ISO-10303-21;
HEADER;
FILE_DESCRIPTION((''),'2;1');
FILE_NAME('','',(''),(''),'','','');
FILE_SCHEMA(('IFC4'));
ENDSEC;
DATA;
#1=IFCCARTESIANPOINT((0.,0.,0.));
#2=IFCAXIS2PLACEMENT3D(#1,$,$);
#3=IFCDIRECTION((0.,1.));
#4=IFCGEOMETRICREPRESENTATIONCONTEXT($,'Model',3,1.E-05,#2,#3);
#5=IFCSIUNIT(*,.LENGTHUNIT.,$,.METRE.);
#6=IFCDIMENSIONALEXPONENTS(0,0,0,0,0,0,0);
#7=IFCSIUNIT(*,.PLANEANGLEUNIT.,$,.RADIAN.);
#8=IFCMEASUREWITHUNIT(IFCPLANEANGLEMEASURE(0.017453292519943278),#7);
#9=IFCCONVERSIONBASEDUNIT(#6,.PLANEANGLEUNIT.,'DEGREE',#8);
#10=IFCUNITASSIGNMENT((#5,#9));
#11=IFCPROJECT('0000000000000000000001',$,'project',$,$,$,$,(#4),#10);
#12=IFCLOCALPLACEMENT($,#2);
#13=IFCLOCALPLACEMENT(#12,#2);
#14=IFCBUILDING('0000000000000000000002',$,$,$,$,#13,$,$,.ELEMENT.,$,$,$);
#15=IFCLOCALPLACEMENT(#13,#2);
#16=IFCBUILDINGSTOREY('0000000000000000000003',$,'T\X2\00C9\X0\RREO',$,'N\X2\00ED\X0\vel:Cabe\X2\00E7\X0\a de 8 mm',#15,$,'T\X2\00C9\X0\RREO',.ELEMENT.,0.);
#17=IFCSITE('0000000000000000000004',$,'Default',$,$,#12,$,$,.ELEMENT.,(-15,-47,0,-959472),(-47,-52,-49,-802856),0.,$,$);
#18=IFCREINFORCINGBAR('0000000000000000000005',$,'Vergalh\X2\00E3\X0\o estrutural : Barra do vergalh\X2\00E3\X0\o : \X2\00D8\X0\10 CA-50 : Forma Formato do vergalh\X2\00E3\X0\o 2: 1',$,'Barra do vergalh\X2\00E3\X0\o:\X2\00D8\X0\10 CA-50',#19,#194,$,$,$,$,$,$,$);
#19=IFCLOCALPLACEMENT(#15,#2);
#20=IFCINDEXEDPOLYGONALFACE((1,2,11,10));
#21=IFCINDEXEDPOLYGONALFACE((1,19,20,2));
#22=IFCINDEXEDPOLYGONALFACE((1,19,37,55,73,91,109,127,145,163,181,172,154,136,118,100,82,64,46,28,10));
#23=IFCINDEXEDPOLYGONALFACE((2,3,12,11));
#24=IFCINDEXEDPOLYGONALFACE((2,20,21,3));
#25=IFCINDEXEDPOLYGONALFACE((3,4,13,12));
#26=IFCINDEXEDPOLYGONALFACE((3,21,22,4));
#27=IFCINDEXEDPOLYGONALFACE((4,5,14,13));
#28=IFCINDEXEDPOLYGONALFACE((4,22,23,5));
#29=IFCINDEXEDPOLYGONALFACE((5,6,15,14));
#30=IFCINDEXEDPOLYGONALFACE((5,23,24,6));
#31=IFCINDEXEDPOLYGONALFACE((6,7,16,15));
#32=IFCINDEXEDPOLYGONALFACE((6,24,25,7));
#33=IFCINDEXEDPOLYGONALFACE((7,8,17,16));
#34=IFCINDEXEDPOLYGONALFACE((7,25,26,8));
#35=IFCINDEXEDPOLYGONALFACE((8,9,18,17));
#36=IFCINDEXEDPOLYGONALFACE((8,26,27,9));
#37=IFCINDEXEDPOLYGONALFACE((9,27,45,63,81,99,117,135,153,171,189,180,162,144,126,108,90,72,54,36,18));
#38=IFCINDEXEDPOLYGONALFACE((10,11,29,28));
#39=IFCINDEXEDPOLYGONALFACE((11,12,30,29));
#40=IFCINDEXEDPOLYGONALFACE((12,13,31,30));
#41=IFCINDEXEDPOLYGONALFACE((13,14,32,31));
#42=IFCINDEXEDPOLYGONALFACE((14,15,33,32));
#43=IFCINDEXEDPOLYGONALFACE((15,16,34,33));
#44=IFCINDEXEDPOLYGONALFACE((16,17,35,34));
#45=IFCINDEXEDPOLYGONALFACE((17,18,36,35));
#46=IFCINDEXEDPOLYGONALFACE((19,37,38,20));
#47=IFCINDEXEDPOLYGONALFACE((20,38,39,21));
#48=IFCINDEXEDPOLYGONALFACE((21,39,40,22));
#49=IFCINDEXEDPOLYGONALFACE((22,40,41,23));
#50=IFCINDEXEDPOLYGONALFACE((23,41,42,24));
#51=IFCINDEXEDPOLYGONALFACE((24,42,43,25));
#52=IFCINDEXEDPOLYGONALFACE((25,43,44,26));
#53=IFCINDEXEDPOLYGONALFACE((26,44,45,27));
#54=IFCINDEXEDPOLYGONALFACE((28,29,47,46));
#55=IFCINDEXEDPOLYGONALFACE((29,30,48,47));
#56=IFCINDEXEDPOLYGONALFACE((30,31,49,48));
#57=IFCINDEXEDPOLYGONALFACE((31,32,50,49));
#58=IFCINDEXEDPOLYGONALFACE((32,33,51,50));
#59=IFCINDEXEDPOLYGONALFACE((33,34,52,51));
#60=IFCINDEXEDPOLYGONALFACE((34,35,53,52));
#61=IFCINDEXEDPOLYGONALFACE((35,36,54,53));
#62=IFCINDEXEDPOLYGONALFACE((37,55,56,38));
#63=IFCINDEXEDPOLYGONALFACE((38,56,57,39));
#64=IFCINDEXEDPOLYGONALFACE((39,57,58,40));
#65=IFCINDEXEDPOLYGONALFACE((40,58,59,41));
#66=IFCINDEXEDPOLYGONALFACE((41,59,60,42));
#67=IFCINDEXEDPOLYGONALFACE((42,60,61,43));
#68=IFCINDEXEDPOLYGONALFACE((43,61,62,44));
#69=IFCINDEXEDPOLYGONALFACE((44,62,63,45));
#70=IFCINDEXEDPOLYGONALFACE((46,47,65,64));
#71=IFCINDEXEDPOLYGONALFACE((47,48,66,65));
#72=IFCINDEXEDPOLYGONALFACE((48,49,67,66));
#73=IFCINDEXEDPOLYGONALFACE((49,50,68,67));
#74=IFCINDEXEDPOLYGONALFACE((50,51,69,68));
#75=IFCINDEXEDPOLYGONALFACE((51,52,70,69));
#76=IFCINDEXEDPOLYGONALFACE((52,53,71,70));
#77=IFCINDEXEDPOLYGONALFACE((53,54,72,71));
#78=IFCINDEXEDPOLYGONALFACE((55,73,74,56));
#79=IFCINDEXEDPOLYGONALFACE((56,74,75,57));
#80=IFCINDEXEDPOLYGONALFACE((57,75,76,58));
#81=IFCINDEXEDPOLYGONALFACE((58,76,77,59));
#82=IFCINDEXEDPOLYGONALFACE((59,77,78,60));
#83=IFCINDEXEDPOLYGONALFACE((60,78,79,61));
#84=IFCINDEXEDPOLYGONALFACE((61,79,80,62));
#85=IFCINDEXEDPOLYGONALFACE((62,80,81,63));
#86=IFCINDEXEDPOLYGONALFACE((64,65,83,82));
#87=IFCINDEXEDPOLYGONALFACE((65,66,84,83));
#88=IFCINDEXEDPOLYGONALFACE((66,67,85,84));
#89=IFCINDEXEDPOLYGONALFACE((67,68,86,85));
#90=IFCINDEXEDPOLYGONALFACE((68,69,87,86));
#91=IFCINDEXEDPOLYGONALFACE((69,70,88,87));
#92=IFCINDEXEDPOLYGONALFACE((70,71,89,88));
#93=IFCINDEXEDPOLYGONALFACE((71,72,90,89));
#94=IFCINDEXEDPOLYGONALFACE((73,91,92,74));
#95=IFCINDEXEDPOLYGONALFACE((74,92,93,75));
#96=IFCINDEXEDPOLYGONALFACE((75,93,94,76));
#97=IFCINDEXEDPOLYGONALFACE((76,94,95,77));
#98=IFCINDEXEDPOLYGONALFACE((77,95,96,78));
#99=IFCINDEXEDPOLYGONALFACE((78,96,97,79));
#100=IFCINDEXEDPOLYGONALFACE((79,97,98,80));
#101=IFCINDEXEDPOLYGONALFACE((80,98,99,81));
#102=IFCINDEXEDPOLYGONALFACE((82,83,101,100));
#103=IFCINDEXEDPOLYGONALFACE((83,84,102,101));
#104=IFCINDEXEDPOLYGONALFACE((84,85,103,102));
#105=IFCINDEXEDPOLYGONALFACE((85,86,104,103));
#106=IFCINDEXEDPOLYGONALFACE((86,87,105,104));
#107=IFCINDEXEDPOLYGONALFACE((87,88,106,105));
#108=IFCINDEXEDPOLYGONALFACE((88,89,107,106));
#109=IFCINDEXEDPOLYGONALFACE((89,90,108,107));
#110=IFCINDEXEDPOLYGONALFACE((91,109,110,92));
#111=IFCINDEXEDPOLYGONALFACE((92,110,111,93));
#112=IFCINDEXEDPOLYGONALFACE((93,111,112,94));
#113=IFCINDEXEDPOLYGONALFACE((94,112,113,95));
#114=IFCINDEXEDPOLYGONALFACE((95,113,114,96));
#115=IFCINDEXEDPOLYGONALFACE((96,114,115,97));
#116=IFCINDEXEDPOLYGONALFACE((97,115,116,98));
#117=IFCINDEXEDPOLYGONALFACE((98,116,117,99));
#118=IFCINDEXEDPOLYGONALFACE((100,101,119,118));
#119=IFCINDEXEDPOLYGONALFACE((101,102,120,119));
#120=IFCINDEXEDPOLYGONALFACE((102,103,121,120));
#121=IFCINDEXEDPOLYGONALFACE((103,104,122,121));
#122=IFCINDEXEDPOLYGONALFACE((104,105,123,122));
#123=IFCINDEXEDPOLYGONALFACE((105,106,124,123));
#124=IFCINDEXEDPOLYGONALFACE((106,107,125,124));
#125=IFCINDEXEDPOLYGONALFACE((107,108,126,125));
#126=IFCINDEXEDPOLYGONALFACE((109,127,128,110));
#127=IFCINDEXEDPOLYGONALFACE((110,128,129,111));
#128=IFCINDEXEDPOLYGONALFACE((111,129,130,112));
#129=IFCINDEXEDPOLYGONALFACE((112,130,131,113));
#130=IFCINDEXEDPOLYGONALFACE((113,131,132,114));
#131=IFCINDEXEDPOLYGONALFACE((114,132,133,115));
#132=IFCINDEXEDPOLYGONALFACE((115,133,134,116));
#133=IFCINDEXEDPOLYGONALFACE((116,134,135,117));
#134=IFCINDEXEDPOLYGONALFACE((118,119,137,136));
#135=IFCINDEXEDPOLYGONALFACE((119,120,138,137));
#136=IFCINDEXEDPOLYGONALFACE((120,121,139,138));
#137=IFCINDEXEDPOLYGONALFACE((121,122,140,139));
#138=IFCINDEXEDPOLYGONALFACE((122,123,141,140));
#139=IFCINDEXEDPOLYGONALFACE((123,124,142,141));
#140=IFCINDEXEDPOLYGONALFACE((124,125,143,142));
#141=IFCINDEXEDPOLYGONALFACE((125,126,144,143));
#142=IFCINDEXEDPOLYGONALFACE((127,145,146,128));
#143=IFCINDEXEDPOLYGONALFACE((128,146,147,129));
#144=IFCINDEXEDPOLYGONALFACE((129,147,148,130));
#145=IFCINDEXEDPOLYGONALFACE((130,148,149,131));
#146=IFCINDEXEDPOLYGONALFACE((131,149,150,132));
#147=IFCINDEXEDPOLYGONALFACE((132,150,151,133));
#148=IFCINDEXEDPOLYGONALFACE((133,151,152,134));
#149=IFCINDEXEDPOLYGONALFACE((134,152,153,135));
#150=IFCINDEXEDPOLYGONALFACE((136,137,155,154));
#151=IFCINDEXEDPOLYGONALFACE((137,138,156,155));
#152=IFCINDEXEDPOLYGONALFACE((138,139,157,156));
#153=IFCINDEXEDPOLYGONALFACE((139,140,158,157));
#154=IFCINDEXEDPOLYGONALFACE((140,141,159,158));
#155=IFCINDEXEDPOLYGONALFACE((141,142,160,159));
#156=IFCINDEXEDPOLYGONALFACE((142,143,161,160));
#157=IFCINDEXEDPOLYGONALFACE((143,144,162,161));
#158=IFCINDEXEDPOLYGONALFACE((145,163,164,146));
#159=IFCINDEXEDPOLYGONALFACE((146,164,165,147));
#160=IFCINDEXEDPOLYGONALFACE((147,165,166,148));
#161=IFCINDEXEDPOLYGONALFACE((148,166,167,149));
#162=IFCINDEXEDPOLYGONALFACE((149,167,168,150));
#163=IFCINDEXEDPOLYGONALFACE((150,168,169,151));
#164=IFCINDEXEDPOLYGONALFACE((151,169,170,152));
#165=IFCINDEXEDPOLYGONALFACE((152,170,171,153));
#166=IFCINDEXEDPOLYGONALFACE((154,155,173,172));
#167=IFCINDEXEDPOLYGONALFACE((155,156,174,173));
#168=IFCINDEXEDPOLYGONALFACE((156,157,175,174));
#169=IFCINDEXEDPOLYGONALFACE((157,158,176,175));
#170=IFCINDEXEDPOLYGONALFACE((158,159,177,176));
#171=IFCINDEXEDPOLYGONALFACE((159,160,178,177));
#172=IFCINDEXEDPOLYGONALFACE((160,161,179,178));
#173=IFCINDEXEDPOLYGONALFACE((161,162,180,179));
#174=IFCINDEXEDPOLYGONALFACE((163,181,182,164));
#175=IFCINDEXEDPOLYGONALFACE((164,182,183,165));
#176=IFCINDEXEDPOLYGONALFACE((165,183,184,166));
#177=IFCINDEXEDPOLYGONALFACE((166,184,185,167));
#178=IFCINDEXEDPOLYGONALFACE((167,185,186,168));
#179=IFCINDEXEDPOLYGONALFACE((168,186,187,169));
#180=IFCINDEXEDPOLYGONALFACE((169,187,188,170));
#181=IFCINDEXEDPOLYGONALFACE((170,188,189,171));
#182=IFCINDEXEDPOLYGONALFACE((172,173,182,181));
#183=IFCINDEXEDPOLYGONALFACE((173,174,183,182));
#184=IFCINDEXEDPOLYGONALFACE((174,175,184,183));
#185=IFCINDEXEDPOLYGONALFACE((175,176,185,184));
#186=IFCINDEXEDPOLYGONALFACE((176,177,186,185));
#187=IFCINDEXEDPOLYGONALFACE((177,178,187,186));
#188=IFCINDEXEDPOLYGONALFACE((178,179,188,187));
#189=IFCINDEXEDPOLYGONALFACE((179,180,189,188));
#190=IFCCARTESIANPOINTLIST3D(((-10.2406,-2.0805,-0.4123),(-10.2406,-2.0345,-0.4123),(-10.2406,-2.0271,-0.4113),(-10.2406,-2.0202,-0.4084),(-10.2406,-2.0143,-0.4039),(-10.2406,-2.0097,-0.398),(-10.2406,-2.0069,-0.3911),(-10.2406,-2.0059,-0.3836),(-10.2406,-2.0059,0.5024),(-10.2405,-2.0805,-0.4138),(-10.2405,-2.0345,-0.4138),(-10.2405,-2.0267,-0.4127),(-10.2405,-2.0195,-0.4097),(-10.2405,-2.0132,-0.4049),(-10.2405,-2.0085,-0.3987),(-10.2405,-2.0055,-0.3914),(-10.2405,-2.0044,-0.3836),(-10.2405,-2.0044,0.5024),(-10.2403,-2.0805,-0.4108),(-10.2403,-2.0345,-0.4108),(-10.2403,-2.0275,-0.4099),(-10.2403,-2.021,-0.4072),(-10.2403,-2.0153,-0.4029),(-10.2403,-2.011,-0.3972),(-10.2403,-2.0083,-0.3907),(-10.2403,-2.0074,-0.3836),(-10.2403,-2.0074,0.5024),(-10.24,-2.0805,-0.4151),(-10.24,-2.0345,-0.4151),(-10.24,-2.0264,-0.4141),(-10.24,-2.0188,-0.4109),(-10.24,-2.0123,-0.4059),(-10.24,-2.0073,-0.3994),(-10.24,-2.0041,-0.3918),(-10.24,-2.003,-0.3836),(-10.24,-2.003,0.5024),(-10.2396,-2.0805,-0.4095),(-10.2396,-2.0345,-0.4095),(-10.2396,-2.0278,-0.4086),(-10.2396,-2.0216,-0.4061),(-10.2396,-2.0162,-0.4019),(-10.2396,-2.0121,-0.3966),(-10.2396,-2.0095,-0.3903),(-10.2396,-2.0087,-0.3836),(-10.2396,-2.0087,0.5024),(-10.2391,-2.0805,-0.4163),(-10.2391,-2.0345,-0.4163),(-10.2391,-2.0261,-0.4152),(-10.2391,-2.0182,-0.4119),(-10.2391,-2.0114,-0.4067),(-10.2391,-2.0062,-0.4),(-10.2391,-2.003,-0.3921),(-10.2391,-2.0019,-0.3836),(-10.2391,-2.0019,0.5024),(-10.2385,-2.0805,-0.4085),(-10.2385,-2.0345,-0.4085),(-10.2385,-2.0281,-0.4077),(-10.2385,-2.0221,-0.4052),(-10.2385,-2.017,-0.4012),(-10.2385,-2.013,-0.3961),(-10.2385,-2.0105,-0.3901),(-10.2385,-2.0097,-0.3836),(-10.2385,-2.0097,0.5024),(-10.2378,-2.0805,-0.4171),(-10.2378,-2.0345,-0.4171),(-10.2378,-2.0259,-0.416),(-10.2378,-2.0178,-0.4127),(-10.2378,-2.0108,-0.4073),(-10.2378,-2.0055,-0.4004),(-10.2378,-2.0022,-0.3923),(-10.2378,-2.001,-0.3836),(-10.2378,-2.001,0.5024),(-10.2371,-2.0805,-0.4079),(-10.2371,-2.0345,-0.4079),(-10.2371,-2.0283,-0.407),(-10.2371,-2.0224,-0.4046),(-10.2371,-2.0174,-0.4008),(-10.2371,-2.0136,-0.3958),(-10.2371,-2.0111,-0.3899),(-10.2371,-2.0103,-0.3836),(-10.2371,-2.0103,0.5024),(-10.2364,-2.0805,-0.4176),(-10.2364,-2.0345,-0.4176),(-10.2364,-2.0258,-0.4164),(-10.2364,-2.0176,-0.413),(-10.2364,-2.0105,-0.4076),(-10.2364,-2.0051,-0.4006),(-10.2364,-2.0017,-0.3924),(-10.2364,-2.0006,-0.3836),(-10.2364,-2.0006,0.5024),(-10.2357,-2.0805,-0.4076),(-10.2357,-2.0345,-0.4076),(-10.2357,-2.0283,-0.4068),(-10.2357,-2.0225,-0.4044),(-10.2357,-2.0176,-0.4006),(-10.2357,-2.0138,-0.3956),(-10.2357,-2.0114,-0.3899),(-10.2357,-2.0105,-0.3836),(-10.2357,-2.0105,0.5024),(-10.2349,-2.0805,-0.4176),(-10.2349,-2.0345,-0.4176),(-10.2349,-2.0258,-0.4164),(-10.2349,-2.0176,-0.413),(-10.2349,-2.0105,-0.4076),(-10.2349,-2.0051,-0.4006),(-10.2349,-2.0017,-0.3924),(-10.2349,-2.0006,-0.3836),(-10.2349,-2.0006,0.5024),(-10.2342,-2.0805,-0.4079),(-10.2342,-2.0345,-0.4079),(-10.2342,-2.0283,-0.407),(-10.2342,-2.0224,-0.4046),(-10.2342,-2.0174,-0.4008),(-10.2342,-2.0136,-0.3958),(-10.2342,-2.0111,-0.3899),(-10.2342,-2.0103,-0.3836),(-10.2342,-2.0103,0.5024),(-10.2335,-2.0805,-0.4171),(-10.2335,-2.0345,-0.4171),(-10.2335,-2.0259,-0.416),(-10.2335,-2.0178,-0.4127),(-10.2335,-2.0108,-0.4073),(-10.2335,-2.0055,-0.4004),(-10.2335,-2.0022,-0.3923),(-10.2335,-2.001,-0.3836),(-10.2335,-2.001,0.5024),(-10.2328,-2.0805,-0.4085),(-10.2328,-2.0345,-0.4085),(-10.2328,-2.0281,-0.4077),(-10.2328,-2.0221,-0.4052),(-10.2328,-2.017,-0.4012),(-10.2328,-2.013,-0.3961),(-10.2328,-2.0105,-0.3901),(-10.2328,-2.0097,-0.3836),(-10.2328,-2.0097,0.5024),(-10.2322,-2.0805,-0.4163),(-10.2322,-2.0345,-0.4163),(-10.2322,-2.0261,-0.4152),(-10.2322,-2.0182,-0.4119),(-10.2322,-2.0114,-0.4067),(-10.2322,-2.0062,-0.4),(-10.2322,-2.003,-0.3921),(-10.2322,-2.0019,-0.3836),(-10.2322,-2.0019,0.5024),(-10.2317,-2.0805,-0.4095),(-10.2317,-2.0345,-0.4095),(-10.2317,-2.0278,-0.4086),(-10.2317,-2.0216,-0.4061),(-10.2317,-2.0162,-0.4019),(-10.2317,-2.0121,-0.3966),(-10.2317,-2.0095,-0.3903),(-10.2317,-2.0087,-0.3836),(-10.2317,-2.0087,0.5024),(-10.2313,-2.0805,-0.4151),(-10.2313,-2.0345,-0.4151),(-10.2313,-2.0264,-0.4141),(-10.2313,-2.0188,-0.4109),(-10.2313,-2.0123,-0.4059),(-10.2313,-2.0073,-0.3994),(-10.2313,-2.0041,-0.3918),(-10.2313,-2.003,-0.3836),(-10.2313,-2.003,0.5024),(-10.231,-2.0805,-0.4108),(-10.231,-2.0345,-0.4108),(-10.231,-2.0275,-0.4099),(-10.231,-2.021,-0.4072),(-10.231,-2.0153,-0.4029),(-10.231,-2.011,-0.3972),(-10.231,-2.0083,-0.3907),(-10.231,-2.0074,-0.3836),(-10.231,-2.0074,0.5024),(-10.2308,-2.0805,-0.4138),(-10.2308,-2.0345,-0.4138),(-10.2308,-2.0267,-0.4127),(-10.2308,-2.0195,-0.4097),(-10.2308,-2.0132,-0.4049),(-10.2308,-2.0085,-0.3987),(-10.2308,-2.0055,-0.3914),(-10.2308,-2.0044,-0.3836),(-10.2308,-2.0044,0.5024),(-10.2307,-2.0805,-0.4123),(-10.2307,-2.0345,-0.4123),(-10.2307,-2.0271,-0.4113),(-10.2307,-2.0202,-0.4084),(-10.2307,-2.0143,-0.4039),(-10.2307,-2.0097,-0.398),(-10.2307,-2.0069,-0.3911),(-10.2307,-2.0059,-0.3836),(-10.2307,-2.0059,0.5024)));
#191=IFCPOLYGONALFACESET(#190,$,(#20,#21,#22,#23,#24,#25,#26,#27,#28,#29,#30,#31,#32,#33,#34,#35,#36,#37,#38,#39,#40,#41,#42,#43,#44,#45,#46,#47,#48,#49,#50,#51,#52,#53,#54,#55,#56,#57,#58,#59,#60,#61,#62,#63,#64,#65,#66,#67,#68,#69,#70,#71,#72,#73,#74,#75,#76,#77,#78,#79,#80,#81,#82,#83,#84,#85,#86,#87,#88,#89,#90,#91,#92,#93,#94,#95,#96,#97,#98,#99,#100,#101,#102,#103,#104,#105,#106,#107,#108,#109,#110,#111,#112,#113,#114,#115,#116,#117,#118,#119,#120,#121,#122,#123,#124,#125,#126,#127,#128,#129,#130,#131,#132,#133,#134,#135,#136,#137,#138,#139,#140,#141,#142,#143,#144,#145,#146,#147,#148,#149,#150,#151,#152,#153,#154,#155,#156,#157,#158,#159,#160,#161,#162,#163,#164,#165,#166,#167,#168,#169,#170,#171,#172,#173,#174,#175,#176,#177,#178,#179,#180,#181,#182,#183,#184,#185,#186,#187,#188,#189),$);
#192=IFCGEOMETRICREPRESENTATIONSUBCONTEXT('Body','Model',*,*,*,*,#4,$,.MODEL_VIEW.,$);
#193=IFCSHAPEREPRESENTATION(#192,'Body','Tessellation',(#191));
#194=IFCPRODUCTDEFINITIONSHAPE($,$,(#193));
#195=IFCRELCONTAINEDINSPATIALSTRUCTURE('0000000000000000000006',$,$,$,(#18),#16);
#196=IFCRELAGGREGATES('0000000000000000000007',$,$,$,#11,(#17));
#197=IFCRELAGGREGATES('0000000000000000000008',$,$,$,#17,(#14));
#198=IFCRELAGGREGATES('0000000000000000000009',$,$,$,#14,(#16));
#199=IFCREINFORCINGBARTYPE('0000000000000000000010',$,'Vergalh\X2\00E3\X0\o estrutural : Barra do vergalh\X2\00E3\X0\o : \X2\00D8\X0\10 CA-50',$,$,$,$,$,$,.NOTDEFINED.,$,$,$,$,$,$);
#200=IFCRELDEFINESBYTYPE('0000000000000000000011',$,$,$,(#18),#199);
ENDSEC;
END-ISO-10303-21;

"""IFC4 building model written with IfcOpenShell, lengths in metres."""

from ifc_helpers import new_model, entity, si_unit, converted_unit, direction, origin, place, context, subcontext, project, spatial, type_object, element, save


model = new_model("IFC4")

# Units and contexts
model_context = context("Model", 3, precision=1e-05, world=origin(), true_north=direction((0.0, 1.0)))
body_context = subcontext(model_context, "Body", "Model", "MODEL_VIEW")
ifc_project = project(units=[si_unit("LENGTHUNIT", "METRE"), converted_unit("PLANEANGLEUNIT", "DEGREE", entity("IfcPlaneAngleMeasure", 0.017453292519943278), si_unit("PLANEANGLEUNIT", "RADIAN"), dimensions=[0, 0, 0, 0, 0, 0, 0])], contexts=[model_context])

# Site, building, storey
site_placement = place(None, origin())
site = spatial("IfcSite", under=ifc_project, at=site_placement, Name="Default", CompositionType="ELEMENT", RefLatitude=(-15, -47, 0, -959472), RefLongitude=(-47, -52, -49, -802856), RefElevation=0.0)
building_placement = place(site_placement, origin())
building = spatial("IfcBuilding", under=site, at=building_placement, CompositionType="ELEMENT")
storey_placement = place(building_placement, origin())
storey = spatial("IfcBuildingStorey", under=building, at=storey_placement, Name="TÉRREO", ObjectType="Nível:Cabeça de 8 mm", LongName="TÉRREO", CompositionType="ELEMENT", Elevation=0.0)

# Reinforcing bar
reinforcing_bar_type_1 = type_object("IfcReinforcingBarType", Name="Vergalhão estrutural : Barra do vergalhão : Ø10 CA-50", PredefinedType="NOTDEFINED")
reinforcing_bar_1_placement = place(storey_placement, origin())
element("IfcReinforcingBar", 1, at=reinforcing_bar_1_placement, inside=storey, type_object=reinforcing_bar_type_1, Name="Vergalhão estrutural : Barra do vergalhão : Ø10 CA-50 : Forma Formato do vergalhão 2: 1", ObjectType="Barra do vergalhão:Ø10 CA-50", context=body_context, shape_type="AdvancedSweptSolid", body=[
    entity("IfcSweptDiskSolid", entity("IfcIndexedPolyCurve", entity("IfcCartesianPointList3D", [[-10.2357, -2.0805, -0.4126], [-10.2357, -2.0345, -0.4126], [-10.2357, -2.014, -0.4042], [-10.2357, -2.0055, -0.3836], [-10.2357, -2.0055, 0.5024]]), [entity("IfcLineIndex", [1, 2]), entity("IfcArcIndex", [2, 3, 4]), entity("IfcLineIndex", [4, 5])], False), 0.005, None, 0.0, 92.0),
])

save(model, "model.ifc")
